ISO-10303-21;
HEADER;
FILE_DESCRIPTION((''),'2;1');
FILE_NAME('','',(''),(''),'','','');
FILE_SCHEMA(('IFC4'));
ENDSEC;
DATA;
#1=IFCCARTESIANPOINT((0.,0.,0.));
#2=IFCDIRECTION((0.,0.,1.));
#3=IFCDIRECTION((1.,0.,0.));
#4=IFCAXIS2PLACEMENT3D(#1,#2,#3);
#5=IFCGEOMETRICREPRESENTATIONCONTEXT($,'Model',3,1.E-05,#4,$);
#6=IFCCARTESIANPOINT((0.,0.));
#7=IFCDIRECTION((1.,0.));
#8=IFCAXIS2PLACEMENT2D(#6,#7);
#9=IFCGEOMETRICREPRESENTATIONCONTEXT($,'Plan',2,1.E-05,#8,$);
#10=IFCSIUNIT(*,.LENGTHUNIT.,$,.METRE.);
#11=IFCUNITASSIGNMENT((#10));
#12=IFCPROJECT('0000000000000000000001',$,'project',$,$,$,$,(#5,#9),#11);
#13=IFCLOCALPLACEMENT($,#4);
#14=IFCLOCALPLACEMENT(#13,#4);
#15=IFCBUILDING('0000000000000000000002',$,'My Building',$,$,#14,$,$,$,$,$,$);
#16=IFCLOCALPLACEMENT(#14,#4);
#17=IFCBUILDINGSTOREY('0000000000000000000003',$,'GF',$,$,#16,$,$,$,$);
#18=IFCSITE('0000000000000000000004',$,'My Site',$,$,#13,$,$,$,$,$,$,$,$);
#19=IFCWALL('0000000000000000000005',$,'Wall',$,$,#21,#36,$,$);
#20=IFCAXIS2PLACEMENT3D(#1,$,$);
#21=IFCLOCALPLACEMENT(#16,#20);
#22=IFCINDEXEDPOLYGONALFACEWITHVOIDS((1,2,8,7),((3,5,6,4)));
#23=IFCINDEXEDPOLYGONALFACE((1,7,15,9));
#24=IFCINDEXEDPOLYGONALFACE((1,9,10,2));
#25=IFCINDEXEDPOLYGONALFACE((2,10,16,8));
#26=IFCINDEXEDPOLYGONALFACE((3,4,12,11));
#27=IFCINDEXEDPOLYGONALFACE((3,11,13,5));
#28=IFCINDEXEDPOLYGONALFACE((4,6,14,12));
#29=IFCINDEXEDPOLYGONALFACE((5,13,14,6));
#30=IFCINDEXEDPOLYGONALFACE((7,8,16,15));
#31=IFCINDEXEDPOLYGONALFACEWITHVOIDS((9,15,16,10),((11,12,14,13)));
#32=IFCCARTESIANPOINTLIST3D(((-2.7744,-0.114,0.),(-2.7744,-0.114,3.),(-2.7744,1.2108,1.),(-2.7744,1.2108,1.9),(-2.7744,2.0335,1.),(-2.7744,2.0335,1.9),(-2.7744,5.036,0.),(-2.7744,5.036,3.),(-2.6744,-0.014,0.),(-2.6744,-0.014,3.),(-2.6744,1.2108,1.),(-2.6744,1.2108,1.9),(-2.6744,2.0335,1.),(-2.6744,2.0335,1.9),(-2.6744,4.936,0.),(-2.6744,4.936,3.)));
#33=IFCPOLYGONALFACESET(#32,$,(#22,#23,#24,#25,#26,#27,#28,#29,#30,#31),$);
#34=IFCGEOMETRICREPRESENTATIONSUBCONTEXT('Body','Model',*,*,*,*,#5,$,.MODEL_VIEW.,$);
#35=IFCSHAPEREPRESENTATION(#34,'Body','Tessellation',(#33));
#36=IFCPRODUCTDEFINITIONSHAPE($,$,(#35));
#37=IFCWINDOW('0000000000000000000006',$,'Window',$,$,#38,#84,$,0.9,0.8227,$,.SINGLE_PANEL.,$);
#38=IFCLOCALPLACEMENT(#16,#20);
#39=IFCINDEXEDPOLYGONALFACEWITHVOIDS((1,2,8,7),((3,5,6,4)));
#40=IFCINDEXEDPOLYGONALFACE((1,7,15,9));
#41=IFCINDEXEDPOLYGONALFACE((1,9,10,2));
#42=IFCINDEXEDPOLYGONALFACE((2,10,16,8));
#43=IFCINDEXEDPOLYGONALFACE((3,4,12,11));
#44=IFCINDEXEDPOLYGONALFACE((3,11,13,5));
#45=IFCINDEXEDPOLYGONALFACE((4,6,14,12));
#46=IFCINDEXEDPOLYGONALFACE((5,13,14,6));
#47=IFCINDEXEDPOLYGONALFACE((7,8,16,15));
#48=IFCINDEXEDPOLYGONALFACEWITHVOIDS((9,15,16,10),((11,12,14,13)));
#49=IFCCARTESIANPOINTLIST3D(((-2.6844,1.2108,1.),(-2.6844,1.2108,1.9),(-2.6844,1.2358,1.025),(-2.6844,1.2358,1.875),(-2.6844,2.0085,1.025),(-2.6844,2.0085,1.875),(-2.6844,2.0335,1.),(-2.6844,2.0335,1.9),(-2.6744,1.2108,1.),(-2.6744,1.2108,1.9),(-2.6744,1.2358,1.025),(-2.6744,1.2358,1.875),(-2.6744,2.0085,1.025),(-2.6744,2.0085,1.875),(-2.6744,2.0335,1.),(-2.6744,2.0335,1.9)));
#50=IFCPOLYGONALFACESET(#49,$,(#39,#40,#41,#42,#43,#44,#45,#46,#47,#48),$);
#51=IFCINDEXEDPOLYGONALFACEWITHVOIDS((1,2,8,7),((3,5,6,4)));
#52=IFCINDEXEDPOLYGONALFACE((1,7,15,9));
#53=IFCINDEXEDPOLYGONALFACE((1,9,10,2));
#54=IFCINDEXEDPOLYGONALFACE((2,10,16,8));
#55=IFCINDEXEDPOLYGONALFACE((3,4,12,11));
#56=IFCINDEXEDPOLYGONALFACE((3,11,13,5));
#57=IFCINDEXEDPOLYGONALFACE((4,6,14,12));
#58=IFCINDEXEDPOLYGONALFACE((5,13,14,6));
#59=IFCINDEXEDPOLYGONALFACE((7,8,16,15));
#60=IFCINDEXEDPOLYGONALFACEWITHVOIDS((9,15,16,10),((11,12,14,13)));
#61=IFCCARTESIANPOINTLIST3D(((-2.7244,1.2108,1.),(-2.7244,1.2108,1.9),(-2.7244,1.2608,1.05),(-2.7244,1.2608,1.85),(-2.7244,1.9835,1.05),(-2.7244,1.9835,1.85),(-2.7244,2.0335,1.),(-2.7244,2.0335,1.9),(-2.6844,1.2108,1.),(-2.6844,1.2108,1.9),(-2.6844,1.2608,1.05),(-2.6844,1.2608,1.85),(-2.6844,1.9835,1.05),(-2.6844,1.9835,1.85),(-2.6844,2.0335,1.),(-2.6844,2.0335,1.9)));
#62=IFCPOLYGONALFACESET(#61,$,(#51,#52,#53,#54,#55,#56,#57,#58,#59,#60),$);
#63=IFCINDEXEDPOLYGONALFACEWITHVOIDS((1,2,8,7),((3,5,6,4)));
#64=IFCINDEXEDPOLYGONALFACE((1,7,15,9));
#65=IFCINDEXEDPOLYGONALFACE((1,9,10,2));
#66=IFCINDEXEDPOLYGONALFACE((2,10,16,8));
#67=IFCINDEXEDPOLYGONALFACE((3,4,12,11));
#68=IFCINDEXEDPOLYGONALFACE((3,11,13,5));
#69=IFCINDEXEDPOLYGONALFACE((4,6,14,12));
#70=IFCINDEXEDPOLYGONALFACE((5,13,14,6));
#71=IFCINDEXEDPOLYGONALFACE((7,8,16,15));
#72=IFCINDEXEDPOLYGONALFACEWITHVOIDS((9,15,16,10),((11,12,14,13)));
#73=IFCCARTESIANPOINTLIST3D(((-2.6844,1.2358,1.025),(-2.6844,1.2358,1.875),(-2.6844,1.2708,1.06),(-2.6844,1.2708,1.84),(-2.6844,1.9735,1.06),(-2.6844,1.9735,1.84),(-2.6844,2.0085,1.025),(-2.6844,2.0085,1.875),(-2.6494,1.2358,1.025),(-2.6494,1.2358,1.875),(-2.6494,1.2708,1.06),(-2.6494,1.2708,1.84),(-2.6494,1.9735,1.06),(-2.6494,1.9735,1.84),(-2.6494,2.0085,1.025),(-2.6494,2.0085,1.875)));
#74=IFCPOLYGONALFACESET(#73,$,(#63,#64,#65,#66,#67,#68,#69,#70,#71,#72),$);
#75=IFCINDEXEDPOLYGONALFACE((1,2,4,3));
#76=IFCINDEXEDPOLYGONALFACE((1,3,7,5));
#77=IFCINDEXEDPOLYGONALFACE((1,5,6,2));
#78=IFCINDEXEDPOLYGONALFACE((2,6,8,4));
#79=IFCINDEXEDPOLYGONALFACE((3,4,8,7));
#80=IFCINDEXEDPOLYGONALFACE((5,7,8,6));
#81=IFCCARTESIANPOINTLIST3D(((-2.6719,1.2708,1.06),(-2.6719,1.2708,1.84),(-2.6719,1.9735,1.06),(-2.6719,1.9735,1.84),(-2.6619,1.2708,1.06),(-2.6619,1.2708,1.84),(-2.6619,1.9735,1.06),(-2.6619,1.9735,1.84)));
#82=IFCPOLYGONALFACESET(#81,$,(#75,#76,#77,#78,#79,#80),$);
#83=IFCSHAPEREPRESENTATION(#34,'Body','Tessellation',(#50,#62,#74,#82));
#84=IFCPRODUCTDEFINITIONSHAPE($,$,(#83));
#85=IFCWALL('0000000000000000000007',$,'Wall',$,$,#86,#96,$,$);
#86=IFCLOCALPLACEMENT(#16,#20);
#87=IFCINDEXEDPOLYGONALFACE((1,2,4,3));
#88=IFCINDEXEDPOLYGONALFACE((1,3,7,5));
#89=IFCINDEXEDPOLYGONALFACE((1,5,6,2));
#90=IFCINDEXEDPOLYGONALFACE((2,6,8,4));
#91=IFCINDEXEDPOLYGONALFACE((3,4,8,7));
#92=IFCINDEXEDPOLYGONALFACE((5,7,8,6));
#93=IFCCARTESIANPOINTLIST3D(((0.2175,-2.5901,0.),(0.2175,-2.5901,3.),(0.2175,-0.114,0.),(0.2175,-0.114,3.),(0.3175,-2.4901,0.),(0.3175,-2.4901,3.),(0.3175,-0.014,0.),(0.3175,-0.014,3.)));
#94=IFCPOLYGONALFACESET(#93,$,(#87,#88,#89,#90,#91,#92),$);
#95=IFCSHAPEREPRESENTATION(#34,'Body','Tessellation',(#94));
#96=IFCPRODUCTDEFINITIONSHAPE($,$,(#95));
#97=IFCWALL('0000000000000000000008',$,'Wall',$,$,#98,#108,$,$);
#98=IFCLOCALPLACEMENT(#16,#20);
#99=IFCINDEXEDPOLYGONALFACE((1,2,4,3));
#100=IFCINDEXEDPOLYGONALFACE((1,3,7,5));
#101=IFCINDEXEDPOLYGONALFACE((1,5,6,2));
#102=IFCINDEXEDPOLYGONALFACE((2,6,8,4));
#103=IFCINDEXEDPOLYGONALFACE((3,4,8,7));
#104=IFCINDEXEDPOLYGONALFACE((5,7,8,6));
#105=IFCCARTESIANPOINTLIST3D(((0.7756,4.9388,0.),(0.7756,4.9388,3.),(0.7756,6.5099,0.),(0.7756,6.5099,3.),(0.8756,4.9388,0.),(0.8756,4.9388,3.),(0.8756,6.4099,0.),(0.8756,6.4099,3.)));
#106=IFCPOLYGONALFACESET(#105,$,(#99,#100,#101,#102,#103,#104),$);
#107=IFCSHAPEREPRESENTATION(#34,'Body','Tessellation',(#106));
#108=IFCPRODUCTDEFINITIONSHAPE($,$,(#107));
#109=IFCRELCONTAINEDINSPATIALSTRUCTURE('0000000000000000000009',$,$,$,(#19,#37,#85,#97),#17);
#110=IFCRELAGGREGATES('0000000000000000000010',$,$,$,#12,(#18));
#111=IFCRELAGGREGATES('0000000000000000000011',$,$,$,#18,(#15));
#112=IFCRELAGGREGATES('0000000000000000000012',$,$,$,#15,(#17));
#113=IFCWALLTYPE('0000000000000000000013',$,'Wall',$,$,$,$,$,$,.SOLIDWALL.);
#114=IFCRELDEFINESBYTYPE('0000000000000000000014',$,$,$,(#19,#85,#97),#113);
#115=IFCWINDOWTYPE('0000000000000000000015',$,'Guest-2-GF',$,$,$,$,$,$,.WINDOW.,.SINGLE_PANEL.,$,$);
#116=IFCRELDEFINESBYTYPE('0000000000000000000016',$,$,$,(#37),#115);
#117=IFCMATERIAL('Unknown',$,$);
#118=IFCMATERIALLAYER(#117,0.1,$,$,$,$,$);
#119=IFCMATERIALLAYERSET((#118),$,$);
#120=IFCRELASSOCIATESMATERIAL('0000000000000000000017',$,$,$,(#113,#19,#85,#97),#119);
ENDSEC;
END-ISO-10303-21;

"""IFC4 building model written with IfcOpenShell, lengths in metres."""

from ifc_helpers import new_model, entity, si_unit, frame, origin_with_axes, origin_2d_with_axis, place, context, subcontext, project, spatial, line, indexed_curve, outline, extrude, shape, source, transform, mapped, material, layer, layer_set, layer_usage, type_object, type_shapes, element, fill, save


model = new_model("IFC4")

# Units and contexts
model_context = context("Model", 3, precision=1e-05, world=origin_with_axes())
plan_context = context("Plan", 2, precision=1e-05, world=origin_2d_with_axis())
body_context_1 = subcontext(model_context, "Body", "Model", "MODEL_VIEW")
body_context_2 = subcontext(plan_context, "Body", "Plan", "PLAN_VIEW")
ifc_project = project(units=[si_unit("LENGTHUNIT", "METRE")], contexts=[model_context, plan_context])

# Site, building, storey
site_placement = place(None, origin_with_axes())
site = spatial("IfcSite", under=ifc_project, at=site_placement, Name="My Site")
building_placement = place(site_placement, origin_with_axes())
building = spatial("IfcBuilding", under=site, at=building_placement, Name="My Building")
storey_placement = place(building_placement, origin_with_axes())
storey = spatial("IfcBuildingStorey", under=building, at=storey_placement, Name="GF")

# Shared definitions
ifc_material_1 = material(Name="Unknown")

# Shared definitions
ifc_layer_1 = layer(ifc_material_1, 0.1)
ifc_layer_set_1 = layer_set([ifc_layer_1])
wall_type = type_object("IfcWallType", Name="Wall", PredefinedType="SOLIDWALL", material=ifc_layer_set_1)

# Wall, opening, window
ifc_layer_usage_1 = layer_usage(ifc_layer_set_1, "AXIS2", "POSITIVE", 0.0)
wall_1_placement = place(storey_placement, frame((-2.7744, 5.036, 0.0), z_axis=(0.0, 0.0, 1.0), x_axis=(0.0, -1.0, 0.0)))
wall_1 = element("IfcWall", 1, at=wall_1_placement, inside=storey, type_object=wall_type, material=ifc_layer_usage_1, Name="Wall", context=body_context_1, shape_type="SweptSolid", body=[
    extrude(outline(indexed_curve([(0.0, 0.0), (0.1, 0.1), (5.05, 0.1), (5.15, 0.0)], segments=[line(1, 2, 3, 4, 1)])), origin_with_axes(), (0.0, 0.0, 1.0), 3.0),
])
shared_shape_1 = source(origin_with_axes(), body_context_1, "Body", "SweptSolid", [
    extrude(outline(indexed_curve([(0.0, 0.0), (0.8227, 0.0), (0.8227, 0.9), (0.0, 0.9)], segments=[line(1, 2, 3, 4, 1)])), frame((0.0, -0.6, 0.0), z_axis=(0.0, -1.0, 0.0), x_axis=(1.0, 0.0, 0.0)), (0.0, 0.0, -1.0), 1.2),
])
opening_1_placement = place(wall_1_placement, frame((3.0025, 0.0, 1.0), z_axis=(0.0, 0.0, 1.0), x_axis=(1.0, 0.0, 0.0)))
opening_1 = element("IfcOpeningElement", 2, at=opening_1_placement, cuts=wall_1, PredefinedType="OPENING", context=body_context_1, shape_type="MappedRepresentation", body=[
    mapped(shared_shape_1, transform((0.0, 0.0, 0.0), x_axis=(1.0, 0.0, 0.0), y_axis=(0.0, 1.0, 0.0), z_axis=(0.0, 0.0, 1.0), scale=1.0)),
])
window_type_1 = type_object("IfcWindowType", Name="Guest-2-GF", PartitioningType="SINGLE_PANEL", PredefinedType="WINDOW")
shared_shape_2 = source(origin_with_axes(), body_context_1, "Body", "SweptSolid", [
    extrude(outline(indexed_curve([(0.0, 0.0), (0.8227, 0.0), (0.8227, 0.9), (0.0, 0.9)], segments=[line(1, 2, 3, 4, 1)]), holes=[indexed_curve([(0.025, 0.025), (0.7977, 0.025), (0.7977, 0.875), (0.025, 0.875)], segments=[line(1, 2, 3, 4, 1)])]), frame((0.0, 0.09, 0.0), z_axis=(0.0, -1.0, 0.0), x_axis=(1.0, 0.0, 0.0)), (0.0, 0.0, -1.0), 0.01),
    extrude(outline(indexed_curve([(0.0, 0.0), (0.8227, 0.0), (0.8227, 0.9), (0.0, 0.9)], segments=[line(1, 2, 3, 4, 1)]), holes=[indexed_curve([(0.05, 0.05), (0.7727, 0.05), (0.7727, 0.85), (0.05, 0.85)], segments=[line(1, 2, 3, 4, 1)])]), frame((0.0, 0.05, 0.0), z_axis=(0.0, -1.0, 0.0), x_axis=(1.0, 0.0, 0.0)), (0.0, 0.0, -1.0), 0.04),
    extrude(outline(indexed_curve([(0.0, 0.0), (0.7727, 0.0), (0.7727, 0.85), (0.0, 0.85)], segments=[line(1, 2, 3, 4, 1)]), holes=[indexed_curve([(0.035, 0.035), (0.7377, 0.035), (0.7377, 0.815), (0.035, 0.815)], segments=[line(1, 2, 3, 4, 1)])]), frame((0.025, 0.09, 0.025), z_axis=(0.0, -1.0, 0.0), x_axis=(1.0, 0.0, 0.0)), (0.0, 0.0, -1.0), 0.035),
    extrude(outline(indexed_curve([(0.035, 0.035), (0.7377, 0.035), (0.7377, 0.815), (0.035, 0.815)], segments=[line(1, 2, 3, 4, 1)])), frame((0.025, 0.1025, 0.025), z_axis=(0.0, -1.0, 0.0), x_axis=(1.0, 0.0, 0.0)), (0.0, 0.0, -1.0), 0.01),
])
shared_shape_3 = source(origin_with_axes(), body_context_2, "Body", "Curve2D", [
    entity("IfcIndexedPolyCurve", entity("IfcCartesianPointList2D", [[0.05, 0.05], [0.7727, 0.05]])),
    entity("IfcIndexedPolyCurve", entity("IfcCartesianPointList2D", [[0.0, 0.1], [0.025, 0.1], [0.025, 0.09], [0.05, 0.09], [0.05, 0.05], [0.0, 0.05]]), [entity("IfcLineIndex", [1, 2, 3, 4, 5, 6, 1])]),
    entity("IfcIndexedPolyCurve", entity("IfcCartesianPointList2D", [[0.8227, 0.1], [0.7977, 0.1], [0.7977, 0.09], [0.7727, 0.09], [0.7727, 0.05], [0.8227, 0.05]]), [entity("IfcLineIndex", [1, 2, 3, 4, 5, 6, 1])]),
    entity("IfcIndexedPolyCurve", entity("IfcCartesianPointList2D", [[0.025, 0.09], [0.06, 0.09], [0.06, 0.125], [0.025, 0.125]]), [entity("IfcLineIndex", [1, 2, 3, 4, 1])]),
    entity("IfcIndexedPolyCurve", entity("IfcCartesianPointList2D", [[0.7977, 0.09], [0.7627, 0.09], [0.7627, 0.125], [0.7977, 0.125]]), [entity("IfcLineIndex", [1, 2, 3, 4, 1])]),
    entity("IfcIndexedPolyCurve", entity("IfcCartesianPointList2D", [[0.06, 0.09], [0.7627, 0.09]])),
    entity("IfcIndexedPolyCurve", entity("IfcCartesianPointList2D", [[0.06, 0.125], [0.7627, 0.125]])),
    entity("IfcIndexedPolyCurve", entity("IfcCartesianPointList2D", [[0.06, 0.1075], [0.7627, 0.1075]])),
])
type_shapes(window_type_1, [shared_shape_2, shared_shape_3])
window_1_placement = place(opening_1_placement, frame((0.0, 0.0, 0.0), z_axis=(0.0, 0.0, 1.0), x_axis=(1.0, 0.0, 0.0)))
window_1 = element("IfcWindow", 3, at=window_1_placement, inside=storey, type_object=window_type_1, Name="Window", OverallHeight=0.9, OverallWidth=0.8227, PartitioningType="SINGLE_PANEL", shapes=[
    shape(body_context_1, "Body", "MappedRepresentation", [mapped(shared_shape_2, transform((0.0, 0.0, 0.0), x_axis=(1.0, 0.0, 0.0), y_axis=(0.0, 1.0, 0.0), z_axis=(0.0, 0.0, 1.0), scale=1.0))]),
    shape(body_context_2, "Body", "MappedRepresentation", [mapped(shared_shape_3, transform((0.0, 0.0, 0.0), x_axis=(1.0, 0.0, 0.0), y_axis=(0.0, 1.0, 0.0), z_axis=(0.0, 0.0, 1.0), scale=1.0))]),
])
fill(opening_1, window_1)

# Wall
ifc_layer_usage_2 = layer_usage(ifc_layer_set_1, "AXIS2", "POSITIVE", 0.0)
wall_2_placement = place(storey_placement, frame((0.2175, -0.114, 0.0), z_axis=(0.0, 0.0, 1.0), x_axis=(0.0, -1.0, 0.0)))
element("IfcWall", 4, at=wall_2_placement, inside=storey, type_object=wall_type, material=ifc_layer_usage_2, Name="Wall", context=body_context_1, shape_type="SweptSolid", body=[
    extrude(outline(indexed_curve([(0.0, 0.0), (-0.1, 0.1), (2.3761, 0.1), (2.4761, 0.0)], segments=[line(1, 2, 3, 4, 1)])), origin_with_axes(), (0.0, 0.0, 1.0), 3.0),
])

# Wall
ifc_layer_usage_3 = layer_usage(ifc_layer_set_1, "AXIS2", "POSITIVE", 0.0)
wall_3_placement = place(storey_placement, frame((0.7756, 6.5099, 0.0), z_axis=(0.0, 0.0, 1.0), x_axis=(0.0, -1.0, 0.0)))
element("IfcWall", 5, at=wall_3_placement, inside=storey, type_object=wall_type, material=ifc_layer_usage_3, Name="Wall", context=body_context_1, shape_type="SweptSolid", body=[
    extrude(outline(indexed_curve([(0.0, 0.0), (0.1, 0.1), (1.5711, 0.1), (1.5711, 0.0)], segments=[line(1, 2, 3, 4, 1)])), origin_with_axes(), (0.0, 0.0, 1.0), 3.0),
])

save(model, "model.ifc")
